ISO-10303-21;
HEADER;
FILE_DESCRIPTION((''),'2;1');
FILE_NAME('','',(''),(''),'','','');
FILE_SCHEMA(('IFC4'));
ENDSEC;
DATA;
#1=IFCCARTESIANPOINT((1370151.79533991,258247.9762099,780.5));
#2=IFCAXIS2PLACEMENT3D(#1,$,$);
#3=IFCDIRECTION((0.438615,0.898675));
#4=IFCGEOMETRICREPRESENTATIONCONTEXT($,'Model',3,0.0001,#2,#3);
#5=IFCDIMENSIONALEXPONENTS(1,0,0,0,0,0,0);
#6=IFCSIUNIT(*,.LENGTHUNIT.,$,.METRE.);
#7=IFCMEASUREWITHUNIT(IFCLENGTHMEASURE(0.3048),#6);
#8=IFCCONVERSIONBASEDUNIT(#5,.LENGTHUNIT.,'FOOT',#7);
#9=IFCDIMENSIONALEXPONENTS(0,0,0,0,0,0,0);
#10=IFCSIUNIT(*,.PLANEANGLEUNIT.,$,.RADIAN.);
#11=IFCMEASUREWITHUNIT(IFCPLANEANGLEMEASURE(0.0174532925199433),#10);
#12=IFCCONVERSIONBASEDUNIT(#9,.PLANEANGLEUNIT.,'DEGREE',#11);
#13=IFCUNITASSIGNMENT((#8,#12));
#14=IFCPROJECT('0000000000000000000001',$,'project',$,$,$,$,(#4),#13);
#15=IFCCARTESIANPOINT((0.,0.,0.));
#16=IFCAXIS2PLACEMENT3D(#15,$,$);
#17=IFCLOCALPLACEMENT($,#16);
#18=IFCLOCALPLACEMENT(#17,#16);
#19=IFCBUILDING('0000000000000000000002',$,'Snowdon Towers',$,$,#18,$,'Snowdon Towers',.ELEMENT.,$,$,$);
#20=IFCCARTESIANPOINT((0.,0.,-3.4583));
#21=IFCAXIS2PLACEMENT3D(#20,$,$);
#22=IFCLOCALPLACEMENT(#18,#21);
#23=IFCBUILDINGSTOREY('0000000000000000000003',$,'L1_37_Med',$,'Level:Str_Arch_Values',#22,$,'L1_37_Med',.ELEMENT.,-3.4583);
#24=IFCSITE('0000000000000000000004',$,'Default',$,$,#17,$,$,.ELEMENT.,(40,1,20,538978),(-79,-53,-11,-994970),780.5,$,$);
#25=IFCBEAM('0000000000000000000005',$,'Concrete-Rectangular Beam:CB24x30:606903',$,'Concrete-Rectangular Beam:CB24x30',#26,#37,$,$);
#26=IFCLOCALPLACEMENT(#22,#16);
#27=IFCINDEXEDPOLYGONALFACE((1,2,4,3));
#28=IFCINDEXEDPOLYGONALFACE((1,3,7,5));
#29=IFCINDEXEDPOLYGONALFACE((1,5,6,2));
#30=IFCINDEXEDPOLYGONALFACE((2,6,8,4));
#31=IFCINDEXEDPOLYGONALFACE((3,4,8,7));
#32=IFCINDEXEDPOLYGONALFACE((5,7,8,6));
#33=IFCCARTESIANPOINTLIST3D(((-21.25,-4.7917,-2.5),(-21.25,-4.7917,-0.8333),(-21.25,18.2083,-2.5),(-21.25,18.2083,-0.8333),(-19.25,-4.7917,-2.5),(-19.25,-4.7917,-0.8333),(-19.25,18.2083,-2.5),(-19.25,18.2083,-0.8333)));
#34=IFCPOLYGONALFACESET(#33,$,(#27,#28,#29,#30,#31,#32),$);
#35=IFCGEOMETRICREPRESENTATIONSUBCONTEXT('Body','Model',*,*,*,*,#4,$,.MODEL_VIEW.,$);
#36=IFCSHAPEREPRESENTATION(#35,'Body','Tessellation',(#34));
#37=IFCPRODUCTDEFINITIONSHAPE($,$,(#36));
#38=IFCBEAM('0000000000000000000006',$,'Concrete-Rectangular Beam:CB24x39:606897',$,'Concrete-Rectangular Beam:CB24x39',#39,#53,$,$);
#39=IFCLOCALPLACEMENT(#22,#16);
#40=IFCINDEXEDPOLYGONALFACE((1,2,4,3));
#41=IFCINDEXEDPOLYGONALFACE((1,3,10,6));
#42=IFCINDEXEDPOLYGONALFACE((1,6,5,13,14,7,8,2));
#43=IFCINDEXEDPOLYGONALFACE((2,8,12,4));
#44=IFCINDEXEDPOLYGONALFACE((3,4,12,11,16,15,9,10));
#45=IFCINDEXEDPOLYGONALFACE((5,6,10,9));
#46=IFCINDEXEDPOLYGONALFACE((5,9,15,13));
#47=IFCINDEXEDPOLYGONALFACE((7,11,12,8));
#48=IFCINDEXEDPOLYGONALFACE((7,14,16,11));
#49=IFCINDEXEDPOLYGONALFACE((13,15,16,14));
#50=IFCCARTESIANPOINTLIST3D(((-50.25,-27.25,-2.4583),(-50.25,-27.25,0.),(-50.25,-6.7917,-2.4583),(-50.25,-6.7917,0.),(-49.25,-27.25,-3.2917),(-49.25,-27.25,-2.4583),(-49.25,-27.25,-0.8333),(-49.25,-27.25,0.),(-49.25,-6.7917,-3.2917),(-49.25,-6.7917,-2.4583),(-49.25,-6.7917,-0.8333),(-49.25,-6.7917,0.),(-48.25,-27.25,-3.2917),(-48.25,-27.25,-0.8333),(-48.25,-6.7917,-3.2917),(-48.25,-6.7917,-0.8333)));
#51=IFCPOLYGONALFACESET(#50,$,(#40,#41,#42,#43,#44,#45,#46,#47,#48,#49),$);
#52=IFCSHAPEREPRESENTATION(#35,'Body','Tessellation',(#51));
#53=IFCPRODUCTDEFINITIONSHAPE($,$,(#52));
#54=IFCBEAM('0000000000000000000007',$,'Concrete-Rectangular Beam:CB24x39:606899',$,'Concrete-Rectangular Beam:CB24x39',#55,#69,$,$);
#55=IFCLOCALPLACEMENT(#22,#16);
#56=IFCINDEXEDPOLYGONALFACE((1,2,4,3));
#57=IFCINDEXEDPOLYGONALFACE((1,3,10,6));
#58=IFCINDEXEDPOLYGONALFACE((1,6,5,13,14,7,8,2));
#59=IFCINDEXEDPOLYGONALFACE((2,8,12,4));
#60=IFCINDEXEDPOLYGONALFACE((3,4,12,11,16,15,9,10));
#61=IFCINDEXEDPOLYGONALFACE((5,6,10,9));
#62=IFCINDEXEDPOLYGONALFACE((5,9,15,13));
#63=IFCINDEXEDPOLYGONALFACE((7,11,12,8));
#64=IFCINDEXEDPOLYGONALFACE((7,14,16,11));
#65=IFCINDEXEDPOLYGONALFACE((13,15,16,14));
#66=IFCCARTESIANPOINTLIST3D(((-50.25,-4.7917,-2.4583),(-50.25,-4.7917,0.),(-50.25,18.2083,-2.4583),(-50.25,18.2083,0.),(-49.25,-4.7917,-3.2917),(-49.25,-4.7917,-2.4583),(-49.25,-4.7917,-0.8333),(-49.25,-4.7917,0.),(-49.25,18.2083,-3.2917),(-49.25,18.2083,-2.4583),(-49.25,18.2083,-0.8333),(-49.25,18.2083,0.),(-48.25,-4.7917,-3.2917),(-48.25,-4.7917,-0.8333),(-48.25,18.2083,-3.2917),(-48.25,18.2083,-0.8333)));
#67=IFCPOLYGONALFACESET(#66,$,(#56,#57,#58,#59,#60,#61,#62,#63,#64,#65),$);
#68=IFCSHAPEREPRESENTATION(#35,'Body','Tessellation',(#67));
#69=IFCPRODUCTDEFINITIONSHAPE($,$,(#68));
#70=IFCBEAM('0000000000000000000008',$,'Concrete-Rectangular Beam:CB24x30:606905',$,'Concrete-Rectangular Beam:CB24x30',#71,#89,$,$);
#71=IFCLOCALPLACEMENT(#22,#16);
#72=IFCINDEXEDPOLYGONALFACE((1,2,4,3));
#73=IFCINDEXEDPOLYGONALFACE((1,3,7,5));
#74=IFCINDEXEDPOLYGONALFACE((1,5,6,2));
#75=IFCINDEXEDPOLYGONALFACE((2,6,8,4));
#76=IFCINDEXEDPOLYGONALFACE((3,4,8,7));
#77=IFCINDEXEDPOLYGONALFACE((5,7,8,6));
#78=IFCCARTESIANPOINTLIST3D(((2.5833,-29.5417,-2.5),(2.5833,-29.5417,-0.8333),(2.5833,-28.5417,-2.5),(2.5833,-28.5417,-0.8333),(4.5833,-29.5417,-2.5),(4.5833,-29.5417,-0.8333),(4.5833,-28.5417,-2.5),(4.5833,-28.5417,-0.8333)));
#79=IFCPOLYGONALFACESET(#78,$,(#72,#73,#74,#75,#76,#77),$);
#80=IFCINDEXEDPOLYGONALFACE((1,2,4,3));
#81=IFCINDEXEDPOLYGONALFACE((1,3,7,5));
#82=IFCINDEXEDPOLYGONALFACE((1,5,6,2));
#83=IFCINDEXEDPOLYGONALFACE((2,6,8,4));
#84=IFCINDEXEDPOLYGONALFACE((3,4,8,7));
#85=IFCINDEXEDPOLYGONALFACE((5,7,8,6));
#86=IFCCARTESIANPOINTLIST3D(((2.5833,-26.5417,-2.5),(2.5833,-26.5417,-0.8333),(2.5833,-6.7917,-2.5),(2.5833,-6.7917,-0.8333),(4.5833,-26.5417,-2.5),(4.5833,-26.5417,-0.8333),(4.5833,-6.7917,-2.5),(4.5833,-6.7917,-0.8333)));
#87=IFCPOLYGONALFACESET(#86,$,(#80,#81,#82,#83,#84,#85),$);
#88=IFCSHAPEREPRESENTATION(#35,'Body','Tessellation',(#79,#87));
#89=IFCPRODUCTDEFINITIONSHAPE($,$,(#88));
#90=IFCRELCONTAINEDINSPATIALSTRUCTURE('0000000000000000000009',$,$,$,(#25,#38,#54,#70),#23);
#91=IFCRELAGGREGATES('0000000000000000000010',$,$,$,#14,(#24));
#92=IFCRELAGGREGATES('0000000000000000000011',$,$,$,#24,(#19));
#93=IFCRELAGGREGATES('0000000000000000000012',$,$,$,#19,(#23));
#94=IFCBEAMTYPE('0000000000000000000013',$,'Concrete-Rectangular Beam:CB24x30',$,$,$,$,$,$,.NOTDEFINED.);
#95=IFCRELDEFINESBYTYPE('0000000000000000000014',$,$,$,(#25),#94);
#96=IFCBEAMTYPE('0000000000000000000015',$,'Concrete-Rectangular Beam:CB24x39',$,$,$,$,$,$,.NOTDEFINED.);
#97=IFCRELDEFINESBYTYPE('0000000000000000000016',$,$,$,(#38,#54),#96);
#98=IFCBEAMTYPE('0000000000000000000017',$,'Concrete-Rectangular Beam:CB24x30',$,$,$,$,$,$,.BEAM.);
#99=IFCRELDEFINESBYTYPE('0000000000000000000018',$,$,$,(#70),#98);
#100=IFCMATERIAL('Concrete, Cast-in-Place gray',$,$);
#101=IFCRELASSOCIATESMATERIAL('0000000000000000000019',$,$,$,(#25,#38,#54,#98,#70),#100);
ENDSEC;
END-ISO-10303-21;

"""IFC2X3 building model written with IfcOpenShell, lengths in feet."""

from ifc_helpers import new_model, entity, si_unit, converted_unit, direction, frame, frame_2d, origin, place, context, subcontext, project, spatial, polyline, rectangle, outline, extrude, source, transform, mapped, material, type_object, type_shapes, element, save


model = new_model("IFC2X3")

# Units and contexts
model_context = context("Model", 3, precision=0.0001, world=frame((1370151.79533991, 258247.9762099, 780.5)), true_north=direction((0.438615, 0.898675)))
body_context = subcontext(model_context, "Body", "Model", "MODEL_VIEW")
ifc_project = project(units=[converted_unit("LENGTHUNIT", "FOOT", entity("IfcLengthMeasure", 0.3048), si_unit("LENGTHUNIT", "METRE"), dimensions=[1, 0, 0, 0, 0, 0, 0]), converted_unit("PLANEANGLEUNIT", "DEGREE", entity("IfcPlaneAngleMeasure", 0.0174532925199433), si_unit("PLANEANGLEUNIT", "RADIAN"), dimensions=[0, 0, 0, 0, 0, 0, 0])], contexts=[model_context])

# Site, building, storey
site_placement = place(None, origin())
site = spatial("IfcSite", under=ifc_project, at=site_placement, Name="Default", CompositionType="ELEMENT", RefLatitude=(40, 1, 20, 538978), RefLongitude=(-79, -53, -11, -994970), RefElevation=780.5)
building_placement = place(site_placement, origin())
building = spatial("IfcBuilding", under=site, at=building_placement, Name="Snowdon Towers", LongName="Snowdon Towers", CompositionType="ELEMENT")
storey_placement = place(building_placement, frame((0.0, 0.0, -3.4583)))
storey = spatial("IfcBuildingStorey", under=building, at=storey_placement, Name="L1_37_Med", ObjectType="Level:Str_Arch_Values", LongName="L1_37_Med", CompositionType="ELEMENT", Elevation=-3.4583)

# Beams
ifc_material_1 = material(Name="Concrete, Cast-in-Place gray")
beam_type_1 = type_object("IfcBeamType", Name="Concrete-Rectangular Beam:CB24x30", PredefinedType="NOTDEFINED")
beam_1_placement = place(storey_placement, frame((-20.25, -5.7917, 0.0), z_axis=(0.0, 0.0, 1.0), x_axis=(0.0, 1.0, 0.0)))
element("IfcBeam", 1, at=beam_1_placement, inside=storey, type_object=beam_type_1, material=ifc_material_1, Name="Concrete-Rectangular Beam:CB24x30:606903", ObjectType="Concrete-Rectangular Beam:CB24x30", context=body_context, shape_type="SweptSolid", body=[
    extrude(rectangle(XDim=1.6667, YDim=2.0, at=frame_2d((0.0, 0.0), x_axis=(1.0, 0.0))), frame((1.0, 0.0, -1.6667), z_axis=(1.0, 0.0, 0.0), x_axis=(0.0, 0.0, -1.0)), (0.0, 0.0, 1.0), 23.0),
])
beam_type_2 = type_object("IfcBeamType", Name="Concrete-Rectangular Beam:CB24x39", PredefinedType="NOTDEFINED")
beam_2_placement = place(storey_placement, frame((-49.25, -28.25, 0.0), z_axis=(0.0, 0.0, 1.0), x_axis=(0.0, 1.0, 0.0)))
element("IfcBeam", 2, at=beam_2_placement, inside=storey, type_object=beam_type_2, material=ifc_material_1, Name="Concrete-Rectangular Beam:CB24x39:606897", ObjectType="Concrete-Rectangular Beam:CB24x39", context=body_context, shape_type="SweptSolid", body=[
    extrude(outline(polyline([(-0.8125, -1.0), (1.6458, -1.0), (1.6458, 0.0), (0.8125, 0.0), (0.8125, 1.0), (-1.6458, 1.0), (-1.6458, 0.0), (-0.8125, 0.0), (-0.8125, -1.0)])), frame((1.0, 0.0, -1.6458), z_axis=(1.0, 0.0, 0.0), x_axis=(0.0, 0.0, -1.0)), (0.0, 0.0, 1.0), 20.4583),
])
beam_3_placement = place(storey_placement, frame((-49.25, -4.7917, 0.0), z_axis=(0.0, 0.0, 1.0), x_axis=(0.0, 1.0, 0.0)))
element("IfcBeam", 3, at=beam_3_placement, inside=storey, type_object=beam_type_2, material=ifc_material_1, Name="Concrete-Rectangular Beam:CB24x39:606899", ObjectType="Concrete-Rectangular Beam:CB24x39", context=body_context, shape_type="SweptSolid", body=[
    extrude(outline(polyline([(-0.8125, -1.0), (1.6458, -1.0), (1.6458, 0.0), (0.8125, 0.0), (0.8125, 1.0), (-1.6458, 1.0), (-1.6458, 0.0), (-0.8125, 0.0), (-0.8125, -1.0)])), frame((0.0, 0.0, -1.6458), z_axis=(1.0, 0.0, 0.0), x_axis=(0.0, 0.0, -1.0)), (0.0, 0.0, 1.0), 23.0),
])
beam_type_3 = type_object("IfcBeamType", Name="Concrete-Rectangular Beam:CB24x30", PredefinedType="BEAM", material=ifc_material_1)
shared_shape_1 = source(origin(), body_context, "Body", "SweptSolid", [
    extrude(rectangle(XDim=1.6667, YDim=2.0, at=frame_2d((0.0, 0.0), x_axis=(0.0, 1.0))), frame((3.5833, -29.5417, -5.125), z_axis=(0.0, 1.0, 0.0), x_axis=(-1.0, 0.0, 0.0)), (0.0, 0.0, 1.0), 1.0),
    extrude(rectangle(XDim=1.6667, YDim=2.0, at=frame_2d((0.0, 0.0), x_axis=(0.0, 1.0))), frame((3.5833, -26.5417, -5.125), z_axis=(0.0, 1.0, 0.0), x_axis=(-1.0, 0.0, 0.0)), (0.0, 0.0, 1.0), 19.75),
])
type_shapes(beam_type_3, [shared_shape_1])
beam_4_placement = place(storey_placement, frame((0.0, 0.0, 3.4583)))
element("IfcBeam", 4, at=beam_4_placement, inside=storey, type_object=beam_type_3, material=ifc_material_1, Name="Concrete-Rectangular Beam:CB24x30:606905", ObjectType="Concrete-Rectangular Beam:CB24x30", context=body_context, shape_type="MappedRepresentation", body=[
    mapped(shared_shape_1, transform((0.0, 0.0, 0.0), scale=1.0)),
])

save(model, "model.ifc")
